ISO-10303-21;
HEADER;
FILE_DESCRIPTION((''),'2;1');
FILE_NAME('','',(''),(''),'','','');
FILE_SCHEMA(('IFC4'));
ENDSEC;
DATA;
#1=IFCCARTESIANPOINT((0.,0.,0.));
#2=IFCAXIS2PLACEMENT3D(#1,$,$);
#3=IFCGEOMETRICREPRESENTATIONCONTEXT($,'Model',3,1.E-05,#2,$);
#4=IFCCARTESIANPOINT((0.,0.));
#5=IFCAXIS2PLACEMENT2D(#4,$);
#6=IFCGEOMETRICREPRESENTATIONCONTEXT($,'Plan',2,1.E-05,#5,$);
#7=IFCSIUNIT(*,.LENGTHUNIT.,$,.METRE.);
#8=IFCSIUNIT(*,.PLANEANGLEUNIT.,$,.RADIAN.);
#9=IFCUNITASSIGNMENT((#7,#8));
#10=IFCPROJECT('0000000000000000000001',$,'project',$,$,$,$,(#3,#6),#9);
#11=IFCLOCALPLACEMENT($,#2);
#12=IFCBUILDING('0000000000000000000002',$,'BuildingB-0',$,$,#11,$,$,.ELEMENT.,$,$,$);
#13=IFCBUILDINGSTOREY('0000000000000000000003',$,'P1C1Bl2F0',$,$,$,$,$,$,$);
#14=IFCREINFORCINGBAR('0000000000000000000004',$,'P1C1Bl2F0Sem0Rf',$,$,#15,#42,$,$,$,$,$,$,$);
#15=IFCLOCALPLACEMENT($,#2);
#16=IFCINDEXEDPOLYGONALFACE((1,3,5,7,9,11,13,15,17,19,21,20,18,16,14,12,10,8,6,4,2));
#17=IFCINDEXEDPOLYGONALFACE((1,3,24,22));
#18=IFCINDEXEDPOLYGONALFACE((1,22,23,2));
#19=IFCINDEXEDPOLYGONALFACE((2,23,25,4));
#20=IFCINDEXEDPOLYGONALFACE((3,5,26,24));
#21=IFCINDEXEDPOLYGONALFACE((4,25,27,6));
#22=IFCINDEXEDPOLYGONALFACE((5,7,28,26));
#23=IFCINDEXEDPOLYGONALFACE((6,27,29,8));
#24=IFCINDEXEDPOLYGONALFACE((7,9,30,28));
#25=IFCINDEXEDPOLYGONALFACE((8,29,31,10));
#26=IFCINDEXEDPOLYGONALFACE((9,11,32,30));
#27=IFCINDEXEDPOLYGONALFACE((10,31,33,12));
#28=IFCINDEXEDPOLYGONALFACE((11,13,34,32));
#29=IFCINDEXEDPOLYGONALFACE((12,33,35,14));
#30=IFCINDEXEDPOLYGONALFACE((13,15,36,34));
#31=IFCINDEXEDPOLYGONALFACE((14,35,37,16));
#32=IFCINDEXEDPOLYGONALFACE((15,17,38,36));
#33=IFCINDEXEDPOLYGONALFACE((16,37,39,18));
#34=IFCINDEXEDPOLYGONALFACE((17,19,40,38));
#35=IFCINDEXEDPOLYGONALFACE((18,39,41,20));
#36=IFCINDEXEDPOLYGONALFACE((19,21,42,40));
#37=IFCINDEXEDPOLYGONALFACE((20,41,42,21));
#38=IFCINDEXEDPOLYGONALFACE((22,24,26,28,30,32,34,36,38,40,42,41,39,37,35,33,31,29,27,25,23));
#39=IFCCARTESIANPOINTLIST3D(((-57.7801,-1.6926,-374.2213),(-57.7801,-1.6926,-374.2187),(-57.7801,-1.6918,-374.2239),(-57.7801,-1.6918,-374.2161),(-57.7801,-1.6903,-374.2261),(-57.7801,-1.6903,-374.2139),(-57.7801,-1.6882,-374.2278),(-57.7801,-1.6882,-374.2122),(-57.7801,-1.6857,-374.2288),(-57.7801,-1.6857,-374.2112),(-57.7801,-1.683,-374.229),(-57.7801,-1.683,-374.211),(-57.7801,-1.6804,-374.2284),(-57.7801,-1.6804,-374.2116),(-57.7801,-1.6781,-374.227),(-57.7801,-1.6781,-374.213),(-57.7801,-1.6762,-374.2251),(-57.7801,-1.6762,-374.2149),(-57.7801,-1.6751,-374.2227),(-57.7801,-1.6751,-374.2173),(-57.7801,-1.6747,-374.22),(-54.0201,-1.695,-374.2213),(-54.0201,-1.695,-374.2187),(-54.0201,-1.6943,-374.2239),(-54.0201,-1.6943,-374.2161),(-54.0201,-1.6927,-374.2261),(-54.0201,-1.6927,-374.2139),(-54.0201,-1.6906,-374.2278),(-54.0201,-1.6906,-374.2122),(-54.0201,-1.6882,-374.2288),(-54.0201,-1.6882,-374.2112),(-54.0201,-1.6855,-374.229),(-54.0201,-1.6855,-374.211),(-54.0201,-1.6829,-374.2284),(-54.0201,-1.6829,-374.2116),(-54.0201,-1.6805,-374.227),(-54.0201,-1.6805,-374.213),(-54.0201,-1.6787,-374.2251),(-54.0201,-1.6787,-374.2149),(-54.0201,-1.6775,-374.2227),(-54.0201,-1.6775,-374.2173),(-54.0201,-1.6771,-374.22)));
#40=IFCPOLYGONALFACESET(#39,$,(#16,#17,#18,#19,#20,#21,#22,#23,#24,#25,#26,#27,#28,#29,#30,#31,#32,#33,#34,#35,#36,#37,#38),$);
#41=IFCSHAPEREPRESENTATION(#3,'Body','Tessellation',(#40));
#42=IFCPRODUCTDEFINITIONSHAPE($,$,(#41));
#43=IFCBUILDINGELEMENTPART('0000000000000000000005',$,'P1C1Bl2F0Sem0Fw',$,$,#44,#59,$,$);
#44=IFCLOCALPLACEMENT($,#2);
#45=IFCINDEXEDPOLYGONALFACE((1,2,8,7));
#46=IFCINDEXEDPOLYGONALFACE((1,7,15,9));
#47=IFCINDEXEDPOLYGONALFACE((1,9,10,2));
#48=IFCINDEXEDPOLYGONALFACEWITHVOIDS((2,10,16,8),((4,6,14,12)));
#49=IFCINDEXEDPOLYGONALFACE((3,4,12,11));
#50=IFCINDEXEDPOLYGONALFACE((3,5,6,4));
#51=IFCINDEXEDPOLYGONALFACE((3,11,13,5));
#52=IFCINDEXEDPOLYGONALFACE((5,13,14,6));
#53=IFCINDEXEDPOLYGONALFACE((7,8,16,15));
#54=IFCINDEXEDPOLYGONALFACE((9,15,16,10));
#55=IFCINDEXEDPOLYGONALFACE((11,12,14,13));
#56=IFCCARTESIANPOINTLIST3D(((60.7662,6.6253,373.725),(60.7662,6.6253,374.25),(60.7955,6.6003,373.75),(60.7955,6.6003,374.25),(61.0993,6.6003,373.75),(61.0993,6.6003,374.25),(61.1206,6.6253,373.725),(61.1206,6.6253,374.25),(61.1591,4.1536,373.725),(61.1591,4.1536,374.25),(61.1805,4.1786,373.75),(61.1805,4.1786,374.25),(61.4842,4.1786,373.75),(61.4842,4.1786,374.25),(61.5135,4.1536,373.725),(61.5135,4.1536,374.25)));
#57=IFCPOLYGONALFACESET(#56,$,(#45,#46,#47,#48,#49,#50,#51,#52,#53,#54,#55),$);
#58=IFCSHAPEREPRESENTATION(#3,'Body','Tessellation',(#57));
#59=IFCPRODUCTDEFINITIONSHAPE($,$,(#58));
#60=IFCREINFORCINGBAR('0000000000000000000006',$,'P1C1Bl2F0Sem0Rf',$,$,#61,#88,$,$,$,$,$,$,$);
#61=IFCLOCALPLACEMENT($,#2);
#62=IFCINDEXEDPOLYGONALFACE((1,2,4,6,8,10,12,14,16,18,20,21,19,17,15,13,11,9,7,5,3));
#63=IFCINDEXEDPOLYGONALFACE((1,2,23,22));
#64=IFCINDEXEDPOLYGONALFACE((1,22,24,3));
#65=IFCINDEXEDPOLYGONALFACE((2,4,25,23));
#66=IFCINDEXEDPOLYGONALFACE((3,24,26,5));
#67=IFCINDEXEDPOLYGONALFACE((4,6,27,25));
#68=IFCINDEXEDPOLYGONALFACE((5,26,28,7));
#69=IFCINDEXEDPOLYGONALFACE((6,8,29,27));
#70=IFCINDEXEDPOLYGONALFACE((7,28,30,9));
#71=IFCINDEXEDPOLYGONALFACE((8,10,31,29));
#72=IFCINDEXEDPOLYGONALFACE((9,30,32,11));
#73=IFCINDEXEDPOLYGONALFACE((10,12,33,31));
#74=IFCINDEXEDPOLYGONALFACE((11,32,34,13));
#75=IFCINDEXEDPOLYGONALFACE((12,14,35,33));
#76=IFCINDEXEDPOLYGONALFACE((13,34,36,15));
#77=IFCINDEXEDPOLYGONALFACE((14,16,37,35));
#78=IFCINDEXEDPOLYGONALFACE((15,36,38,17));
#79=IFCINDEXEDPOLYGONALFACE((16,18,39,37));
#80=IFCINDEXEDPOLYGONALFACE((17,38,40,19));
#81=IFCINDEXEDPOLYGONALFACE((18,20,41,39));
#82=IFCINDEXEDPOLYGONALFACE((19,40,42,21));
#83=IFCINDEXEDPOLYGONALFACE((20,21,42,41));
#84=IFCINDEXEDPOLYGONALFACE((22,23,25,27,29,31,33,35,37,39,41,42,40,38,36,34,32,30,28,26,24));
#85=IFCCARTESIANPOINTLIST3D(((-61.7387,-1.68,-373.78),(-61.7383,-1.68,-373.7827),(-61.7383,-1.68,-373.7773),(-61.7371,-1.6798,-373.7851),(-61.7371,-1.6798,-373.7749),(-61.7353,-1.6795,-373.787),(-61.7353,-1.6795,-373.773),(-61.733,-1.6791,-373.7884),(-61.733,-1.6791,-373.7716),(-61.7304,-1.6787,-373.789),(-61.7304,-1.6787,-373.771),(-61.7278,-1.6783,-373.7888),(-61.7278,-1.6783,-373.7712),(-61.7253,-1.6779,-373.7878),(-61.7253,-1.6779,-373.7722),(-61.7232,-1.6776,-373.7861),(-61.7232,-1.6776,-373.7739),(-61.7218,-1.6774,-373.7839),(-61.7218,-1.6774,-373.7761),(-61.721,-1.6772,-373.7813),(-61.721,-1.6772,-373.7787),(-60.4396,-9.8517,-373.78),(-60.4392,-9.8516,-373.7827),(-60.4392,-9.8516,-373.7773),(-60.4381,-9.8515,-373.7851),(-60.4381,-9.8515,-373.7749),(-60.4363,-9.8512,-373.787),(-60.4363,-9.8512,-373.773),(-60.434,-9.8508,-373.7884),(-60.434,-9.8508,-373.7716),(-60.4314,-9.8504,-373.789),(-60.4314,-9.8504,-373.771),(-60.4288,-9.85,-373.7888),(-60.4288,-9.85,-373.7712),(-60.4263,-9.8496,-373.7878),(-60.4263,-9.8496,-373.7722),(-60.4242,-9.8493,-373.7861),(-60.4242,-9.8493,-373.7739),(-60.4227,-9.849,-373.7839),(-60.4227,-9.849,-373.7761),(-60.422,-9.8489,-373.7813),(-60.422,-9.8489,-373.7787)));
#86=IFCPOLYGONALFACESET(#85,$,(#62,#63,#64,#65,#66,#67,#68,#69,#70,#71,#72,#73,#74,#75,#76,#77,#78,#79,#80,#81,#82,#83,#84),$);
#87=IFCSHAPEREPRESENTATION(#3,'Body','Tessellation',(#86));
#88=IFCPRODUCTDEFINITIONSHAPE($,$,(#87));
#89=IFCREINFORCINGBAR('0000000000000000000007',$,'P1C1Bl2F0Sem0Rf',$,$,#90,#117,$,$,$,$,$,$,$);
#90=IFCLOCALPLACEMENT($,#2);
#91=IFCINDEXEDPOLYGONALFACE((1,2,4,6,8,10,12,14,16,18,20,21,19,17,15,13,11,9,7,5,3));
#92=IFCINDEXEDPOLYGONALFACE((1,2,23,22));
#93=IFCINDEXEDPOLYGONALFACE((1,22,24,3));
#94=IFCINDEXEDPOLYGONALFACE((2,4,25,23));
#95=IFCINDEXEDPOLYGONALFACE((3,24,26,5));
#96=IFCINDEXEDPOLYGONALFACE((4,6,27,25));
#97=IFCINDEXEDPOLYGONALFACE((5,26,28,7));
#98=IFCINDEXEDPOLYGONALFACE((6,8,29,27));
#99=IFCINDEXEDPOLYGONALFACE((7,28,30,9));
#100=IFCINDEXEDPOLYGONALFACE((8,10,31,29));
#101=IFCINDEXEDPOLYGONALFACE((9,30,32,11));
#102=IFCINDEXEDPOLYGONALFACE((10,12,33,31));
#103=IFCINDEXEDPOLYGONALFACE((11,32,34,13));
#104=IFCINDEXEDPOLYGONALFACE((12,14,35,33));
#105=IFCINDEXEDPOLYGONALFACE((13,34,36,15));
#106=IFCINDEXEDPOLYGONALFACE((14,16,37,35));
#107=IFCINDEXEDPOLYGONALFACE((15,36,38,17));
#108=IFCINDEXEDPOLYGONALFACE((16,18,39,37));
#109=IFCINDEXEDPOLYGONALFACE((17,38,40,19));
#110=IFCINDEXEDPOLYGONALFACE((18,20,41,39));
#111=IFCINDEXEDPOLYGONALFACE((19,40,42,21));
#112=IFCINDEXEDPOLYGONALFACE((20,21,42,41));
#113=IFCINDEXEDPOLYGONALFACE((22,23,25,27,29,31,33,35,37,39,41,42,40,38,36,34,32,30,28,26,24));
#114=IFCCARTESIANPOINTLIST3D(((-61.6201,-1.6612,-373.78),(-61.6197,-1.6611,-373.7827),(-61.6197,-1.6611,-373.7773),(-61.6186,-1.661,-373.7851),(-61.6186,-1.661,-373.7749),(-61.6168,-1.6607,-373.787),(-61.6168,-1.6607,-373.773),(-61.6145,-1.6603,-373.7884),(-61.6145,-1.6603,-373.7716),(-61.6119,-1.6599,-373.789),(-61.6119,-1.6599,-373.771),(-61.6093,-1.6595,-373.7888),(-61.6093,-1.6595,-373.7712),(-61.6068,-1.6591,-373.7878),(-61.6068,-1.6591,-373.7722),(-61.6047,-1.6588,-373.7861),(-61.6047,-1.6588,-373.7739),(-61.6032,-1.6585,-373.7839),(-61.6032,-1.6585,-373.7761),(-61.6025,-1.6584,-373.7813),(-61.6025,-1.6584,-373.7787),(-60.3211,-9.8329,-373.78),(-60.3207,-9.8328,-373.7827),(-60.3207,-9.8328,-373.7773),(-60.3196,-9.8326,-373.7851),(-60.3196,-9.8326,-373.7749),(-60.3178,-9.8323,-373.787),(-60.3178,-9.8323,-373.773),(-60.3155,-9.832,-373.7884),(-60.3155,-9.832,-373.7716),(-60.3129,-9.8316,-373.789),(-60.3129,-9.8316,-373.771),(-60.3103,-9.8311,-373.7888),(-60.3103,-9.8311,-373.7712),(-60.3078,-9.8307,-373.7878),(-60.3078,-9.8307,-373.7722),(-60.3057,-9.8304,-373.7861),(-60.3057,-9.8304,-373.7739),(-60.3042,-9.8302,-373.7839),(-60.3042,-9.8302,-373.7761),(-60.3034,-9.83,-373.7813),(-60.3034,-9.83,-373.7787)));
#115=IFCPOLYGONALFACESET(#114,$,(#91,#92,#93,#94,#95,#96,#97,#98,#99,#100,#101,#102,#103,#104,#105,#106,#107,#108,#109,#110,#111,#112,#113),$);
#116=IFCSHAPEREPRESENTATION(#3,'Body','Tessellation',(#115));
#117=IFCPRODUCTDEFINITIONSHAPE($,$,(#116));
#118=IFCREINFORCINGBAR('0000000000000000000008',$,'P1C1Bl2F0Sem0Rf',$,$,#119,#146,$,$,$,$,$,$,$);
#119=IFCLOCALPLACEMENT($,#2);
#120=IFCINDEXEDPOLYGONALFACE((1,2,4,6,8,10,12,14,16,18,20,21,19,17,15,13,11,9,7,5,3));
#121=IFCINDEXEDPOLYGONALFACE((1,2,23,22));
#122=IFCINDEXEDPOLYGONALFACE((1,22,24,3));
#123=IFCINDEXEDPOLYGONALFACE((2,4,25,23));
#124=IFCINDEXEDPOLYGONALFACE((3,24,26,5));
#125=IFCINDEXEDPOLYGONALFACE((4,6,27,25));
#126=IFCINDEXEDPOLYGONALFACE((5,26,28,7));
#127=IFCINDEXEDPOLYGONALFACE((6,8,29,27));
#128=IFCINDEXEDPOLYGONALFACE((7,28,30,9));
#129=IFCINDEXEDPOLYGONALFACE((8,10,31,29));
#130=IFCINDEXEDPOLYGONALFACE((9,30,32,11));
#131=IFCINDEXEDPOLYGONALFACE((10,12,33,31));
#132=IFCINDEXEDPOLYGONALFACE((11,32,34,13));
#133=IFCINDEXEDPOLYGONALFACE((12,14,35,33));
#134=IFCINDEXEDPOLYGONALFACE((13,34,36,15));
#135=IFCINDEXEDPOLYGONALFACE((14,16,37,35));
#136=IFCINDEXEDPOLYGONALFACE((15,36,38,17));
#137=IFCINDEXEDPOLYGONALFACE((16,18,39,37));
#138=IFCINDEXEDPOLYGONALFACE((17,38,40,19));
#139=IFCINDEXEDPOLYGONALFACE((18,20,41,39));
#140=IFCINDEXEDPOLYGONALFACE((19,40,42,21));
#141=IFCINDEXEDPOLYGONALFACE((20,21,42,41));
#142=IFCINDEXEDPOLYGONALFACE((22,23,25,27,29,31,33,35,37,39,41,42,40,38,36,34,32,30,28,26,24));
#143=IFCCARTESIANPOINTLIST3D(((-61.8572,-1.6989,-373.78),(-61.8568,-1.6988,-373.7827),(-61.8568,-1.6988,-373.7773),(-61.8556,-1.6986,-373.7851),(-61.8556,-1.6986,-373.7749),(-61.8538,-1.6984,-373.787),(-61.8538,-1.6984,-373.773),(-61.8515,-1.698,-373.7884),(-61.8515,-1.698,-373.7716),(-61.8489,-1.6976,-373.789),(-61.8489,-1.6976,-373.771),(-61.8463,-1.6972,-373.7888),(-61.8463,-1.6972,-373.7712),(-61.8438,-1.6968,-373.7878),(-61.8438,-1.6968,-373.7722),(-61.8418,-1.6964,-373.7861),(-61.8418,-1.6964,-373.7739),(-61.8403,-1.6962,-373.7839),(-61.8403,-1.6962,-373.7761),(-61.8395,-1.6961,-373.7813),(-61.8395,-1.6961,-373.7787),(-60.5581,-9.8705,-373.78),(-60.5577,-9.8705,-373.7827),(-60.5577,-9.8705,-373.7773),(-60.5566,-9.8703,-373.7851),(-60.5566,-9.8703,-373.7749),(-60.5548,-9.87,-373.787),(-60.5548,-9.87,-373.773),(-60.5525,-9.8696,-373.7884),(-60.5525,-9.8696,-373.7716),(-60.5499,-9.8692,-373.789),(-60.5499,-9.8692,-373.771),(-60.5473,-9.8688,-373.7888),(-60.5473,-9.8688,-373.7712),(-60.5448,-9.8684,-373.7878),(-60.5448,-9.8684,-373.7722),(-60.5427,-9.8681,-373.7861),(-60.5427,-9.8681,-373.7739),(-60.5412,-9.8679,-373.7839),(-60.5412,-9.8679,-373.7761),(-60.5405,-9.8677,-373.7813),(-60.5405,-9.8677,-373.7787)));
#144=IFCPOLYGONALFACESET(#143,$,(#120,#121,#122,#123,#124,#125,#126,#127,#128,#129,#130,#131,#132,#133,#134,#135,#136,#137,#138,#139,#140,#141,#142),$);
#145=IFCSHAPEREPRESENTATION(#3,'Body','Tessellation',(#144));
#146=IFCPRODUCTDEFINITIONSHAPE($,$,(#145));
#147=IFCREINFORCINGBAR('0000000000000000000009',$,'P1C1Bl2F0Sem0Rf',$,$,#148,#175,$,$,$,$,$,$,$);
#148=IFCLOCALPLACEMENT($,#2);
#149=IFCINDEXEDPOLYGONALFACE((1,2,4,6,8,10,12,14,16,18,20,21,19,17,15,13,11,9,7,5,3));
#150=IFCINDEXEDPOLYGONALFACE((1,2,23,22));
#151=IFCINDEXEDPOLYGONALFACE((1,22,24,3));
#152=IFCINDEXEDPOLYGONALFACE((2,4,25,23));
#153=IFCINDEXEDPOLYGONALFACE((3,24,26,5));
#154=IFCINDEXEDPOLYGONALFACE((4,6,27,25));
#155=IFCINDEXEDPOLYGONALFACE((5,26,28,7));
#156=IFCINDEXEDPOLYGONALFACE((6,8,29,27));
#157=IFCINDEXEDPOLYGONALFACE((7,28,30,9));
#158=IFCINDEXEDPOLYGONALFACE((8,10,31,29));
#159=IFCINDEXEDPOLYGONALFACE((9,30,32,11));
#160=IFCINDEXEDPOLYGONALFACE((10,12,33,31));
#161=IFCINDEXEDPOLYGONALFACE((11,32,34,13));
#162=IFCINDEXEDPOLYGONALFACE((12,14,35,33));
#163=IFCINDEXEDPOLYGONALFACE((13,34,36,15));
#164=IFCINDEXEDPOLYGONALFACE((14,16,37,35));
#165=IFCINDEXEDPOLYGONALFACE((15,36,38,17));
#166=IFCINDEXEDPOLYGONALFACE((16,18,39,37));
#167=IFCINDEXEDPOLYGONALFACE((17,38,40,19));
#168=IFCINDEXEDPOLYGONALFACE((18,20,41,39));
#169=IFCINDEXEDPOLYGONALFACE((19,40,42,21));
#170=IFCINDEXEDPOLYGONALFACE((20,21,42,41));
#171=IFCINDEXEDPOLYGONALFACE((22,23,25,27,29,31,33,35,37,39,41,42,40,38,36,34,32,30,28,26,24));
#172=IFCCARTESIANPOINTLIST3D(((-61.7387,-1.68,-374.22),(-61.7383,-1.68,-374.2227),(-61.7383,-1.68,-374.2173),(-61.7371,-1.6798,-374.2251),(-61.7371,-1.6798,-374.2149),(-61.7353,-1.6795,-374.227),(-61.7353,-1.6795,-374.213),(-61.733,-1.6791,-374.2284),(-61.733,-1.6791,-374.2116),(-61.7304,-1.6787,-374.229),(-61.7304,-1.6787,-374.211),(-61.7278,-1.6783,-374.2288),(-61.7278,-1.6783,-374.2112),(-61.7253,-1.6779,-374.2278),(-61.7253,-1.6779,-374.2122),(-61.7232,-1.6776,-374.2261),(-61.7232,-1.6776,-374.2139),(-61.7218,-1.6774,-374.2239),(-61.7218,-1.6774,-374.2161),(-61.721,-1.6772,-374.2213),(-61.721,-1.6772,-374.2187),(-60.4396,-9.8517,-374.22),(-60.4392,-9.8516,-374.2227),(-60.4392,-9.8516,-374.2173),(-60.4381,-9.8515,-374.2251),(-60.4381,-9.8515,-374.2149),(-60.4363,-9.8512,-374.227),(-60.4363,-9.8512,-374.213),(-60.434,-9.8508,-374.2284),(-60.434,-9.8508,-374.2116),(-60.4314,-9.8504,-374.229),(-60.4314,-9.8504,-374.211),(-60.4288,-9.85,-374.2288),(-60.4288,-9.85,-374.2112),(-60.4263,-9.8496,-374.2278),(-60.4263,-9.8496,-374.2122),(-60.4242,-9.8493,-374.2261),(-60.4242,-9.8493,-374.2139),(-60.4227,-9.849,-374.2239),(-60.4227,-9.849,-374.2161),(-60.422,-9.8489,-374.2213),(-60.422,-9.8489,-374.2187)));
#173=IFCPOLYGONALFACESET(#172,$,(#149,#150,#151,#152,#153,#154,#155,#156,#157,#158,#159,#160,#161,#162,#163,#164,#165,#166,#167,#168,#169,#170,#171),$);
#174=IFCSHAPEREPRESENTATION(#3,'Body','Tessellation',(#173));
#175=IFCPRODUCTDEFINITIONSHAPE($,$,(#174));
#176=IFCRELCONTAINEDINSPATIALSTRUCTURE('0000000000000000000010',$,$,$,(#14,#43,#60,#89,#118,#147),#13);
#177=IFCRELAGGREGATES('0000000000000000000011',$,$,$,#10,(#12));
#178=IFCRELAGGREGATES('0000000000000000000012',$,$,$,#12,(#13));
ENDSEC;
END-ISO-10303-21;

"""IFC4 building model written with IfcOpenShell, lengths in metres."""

from ifc_helpers import new_model, entity, si_unit, origin, origin_2d, place, context, project, spatial, polyline, outline, extrude, element, save


model = new_model("IFC4")

# Units and contexts
model_context = context("Model", 3, precision=1e-05, world=origin())
plan_context = context("Plan", 2, precision=1e-05, world=origin_2d())
ifc_project = project(units=[si_unit("LENGTHUNIT", "METRE"), si_unit("PLANEANGLEUNIT", "RADIAN")], contexts=[model_context, plan_context])

# Building, storey
building_placement = place(None, origin())
building = spatial("IfcBuilding", under=ifc_project, at=building_placement, Name="BuildingB-0", CompositionType="ELEMENT")
storey = spatial("IfcBuildingStorey", under=building, Name="P1C1Bl2F0")

# Reinforcing bar
element("IfcReinforcingBar", 1, inside=storey, Name="P1C1Bl2F0Sem0Rf", context=model_context, shape_type="SweptSolid", body=[
    entity("IfcSurfaceCurveSweptAreaSolid", entity("IfcCircleProfileDef", "AREA", None, None, 0.009), None, entity("IfcPolyline", [entity("IfcCartesianPoint", [54.0201, 1.6861, 374.22]), entity("IfcCartesianPoint", [57.7801, 1.6837, 374.22])]), None, None, entity("IfcPlane", entity("IfcAxis2Placement3D", entity("IfcCartesianPoint", [54.0201, 1.6861, 374.22]), entity("IfcDirection", [0.0, 0.0, 1.0]), entity("IfcDirection", [1.0, 0.0, 0.0])))),
])

# Building element part, opening
building_element_part_1 = element("IfcBuildingElementPart", 2, inside=storey, Name="P1C1Bl2F0Sem0Fw", context=model_context, shape_type="SweptSolid", body=[
    extrude(outline(polyline([(61.5135, 4.1536, 373.725), (61.1206, 6.6253, 373.725), (60.7662, 6.6253, 373.725), (61.1591, 4.1536, 373.725), (61.5135, 4.1536, 373.725)])), None, (0.0, 0.0, 1.0), 0.525),
])
element("IfcOpeningElement", 3, inside=storey, cuts=building_element_part_1, context=model_context, shape_type="SweptSolid", body=[
    extrude(outline(polyline([(61.4842, 4.1786, 373.75), (61.0993, 6.6003, 373.75), (60.7955, 6.6003, 373.75), (61.1805, 4.1786, 373.75), (61.4842, 4.1786, 373.75)])), None, (0.0, 0.0, 1.0), 0.5),
])

# Reinforcing bars
element("IfcReinforcingBar", 4, inside=storey, Name="P1C1Bl2F0Sem0Rf", context=model_context, shape_type="SweptSolid", body=[
    entity("IfcSurfaceCurveSweptAreaSolid", entity("IfcCircleProfileDef", "AREA", None, None, 0.009), None, entity("IfcPolyline", [entity("IfcCartesianPoint", [60.4307, 9.8503, 373.78]), entity("IfcCartesianPoint", [61.7298, 1.6786, 373.78])]), None, None, entity("IfcPlane", entity("IfcAxis2Placement3D", entity("IfcCartesianPoint", [60.4307, 9.8503, 373.78]), entity("IfcDirection", [0.0, 0.0, 1.0]), entity("IfcDirection", [1.0, 0.0, 0.0])))),
])
element("IfcReinforcingBar", 5, inside=storey, Name="P1C1Bl2F0Sem0Rf", context=model_context, shape_type="SweptSolid", body=[
    entity("IfcSurfaceCurveSweptAreaSolid", entity("IfcCircleProfileDef", "AREA", None, None, 0.009), None, entity("IfcPolyline", [entity("IfcCartesianPoint", [60.3122, 9.8314, 373.78]), entity("IfcCartesianPoint", [61.6113, 1.6598, 373.78])]), None, None, entity("IfcPlane", entity("IfcAxis2Placement3D", entity("IfcCartesianPoint", [60.3122, 9.8314, 373.78]), entity("IfcDirection", [0.0, 0.0, 1.0]), entity("IfcDirection", [1.0, 0.0, 0.0])))),
])
element("IfcReinforcingBar", 6, inside=storey, Name="P1C1Bl2F0Sem0Rf", context=model_context, shape_type="SweptSolid", body=[
    entity("IfcSurfaceCurveSweptAreaSolid", entity("IfcCircleProfileDef", "AREA", None, None, 0.009), None, entity("IfcPolyline", [entity("IfcCartesianPoint", [60.5493, 9.8691, 373.78]), entity("IfcCartesianPoint", [61.8483, 1.6975, 373.78])]), None, None, entity("IfcPlane", entity("IfcAxis2Placement3D", entity("IfcCartesianPoint", [60.5493, 9.8691, 373.78]), entity("IfcDirection", [0.0, 0.0, 1.0]), entity("IfcDirection", [1.0, 0.0, 0.0])))),
])
element("IfcReinforcingBar", 7, inside=storey, Name="P1C1Bl2F0Sem0Rf", context=model_context, shape_type="SweptSolid", body=[
    entity("IfcSurfaceCurveSweptAreaSolid", entity("IfcCircleProfileDef", "AREA", None, None, 0.009), None, entity("IfcPolyline", [entity("IfcCartesianPoint", [60.4307, 9.8503, 374.22]), entity("IfcCartesianPoint", [61.7298, 1.6786, 374.22])]), None, None, entity("IfcPlane", entity("IfcAxis2Placement3D", entity("IfcCartesianPoint", [60.4307, 9.8503, 374.22]), entity("IfcDirection", [0.0, 0.0, 1.0]), entity("IfcDirection", [1.0, 0.0, 0.0])))),
])

save(model, "model.ifc")
